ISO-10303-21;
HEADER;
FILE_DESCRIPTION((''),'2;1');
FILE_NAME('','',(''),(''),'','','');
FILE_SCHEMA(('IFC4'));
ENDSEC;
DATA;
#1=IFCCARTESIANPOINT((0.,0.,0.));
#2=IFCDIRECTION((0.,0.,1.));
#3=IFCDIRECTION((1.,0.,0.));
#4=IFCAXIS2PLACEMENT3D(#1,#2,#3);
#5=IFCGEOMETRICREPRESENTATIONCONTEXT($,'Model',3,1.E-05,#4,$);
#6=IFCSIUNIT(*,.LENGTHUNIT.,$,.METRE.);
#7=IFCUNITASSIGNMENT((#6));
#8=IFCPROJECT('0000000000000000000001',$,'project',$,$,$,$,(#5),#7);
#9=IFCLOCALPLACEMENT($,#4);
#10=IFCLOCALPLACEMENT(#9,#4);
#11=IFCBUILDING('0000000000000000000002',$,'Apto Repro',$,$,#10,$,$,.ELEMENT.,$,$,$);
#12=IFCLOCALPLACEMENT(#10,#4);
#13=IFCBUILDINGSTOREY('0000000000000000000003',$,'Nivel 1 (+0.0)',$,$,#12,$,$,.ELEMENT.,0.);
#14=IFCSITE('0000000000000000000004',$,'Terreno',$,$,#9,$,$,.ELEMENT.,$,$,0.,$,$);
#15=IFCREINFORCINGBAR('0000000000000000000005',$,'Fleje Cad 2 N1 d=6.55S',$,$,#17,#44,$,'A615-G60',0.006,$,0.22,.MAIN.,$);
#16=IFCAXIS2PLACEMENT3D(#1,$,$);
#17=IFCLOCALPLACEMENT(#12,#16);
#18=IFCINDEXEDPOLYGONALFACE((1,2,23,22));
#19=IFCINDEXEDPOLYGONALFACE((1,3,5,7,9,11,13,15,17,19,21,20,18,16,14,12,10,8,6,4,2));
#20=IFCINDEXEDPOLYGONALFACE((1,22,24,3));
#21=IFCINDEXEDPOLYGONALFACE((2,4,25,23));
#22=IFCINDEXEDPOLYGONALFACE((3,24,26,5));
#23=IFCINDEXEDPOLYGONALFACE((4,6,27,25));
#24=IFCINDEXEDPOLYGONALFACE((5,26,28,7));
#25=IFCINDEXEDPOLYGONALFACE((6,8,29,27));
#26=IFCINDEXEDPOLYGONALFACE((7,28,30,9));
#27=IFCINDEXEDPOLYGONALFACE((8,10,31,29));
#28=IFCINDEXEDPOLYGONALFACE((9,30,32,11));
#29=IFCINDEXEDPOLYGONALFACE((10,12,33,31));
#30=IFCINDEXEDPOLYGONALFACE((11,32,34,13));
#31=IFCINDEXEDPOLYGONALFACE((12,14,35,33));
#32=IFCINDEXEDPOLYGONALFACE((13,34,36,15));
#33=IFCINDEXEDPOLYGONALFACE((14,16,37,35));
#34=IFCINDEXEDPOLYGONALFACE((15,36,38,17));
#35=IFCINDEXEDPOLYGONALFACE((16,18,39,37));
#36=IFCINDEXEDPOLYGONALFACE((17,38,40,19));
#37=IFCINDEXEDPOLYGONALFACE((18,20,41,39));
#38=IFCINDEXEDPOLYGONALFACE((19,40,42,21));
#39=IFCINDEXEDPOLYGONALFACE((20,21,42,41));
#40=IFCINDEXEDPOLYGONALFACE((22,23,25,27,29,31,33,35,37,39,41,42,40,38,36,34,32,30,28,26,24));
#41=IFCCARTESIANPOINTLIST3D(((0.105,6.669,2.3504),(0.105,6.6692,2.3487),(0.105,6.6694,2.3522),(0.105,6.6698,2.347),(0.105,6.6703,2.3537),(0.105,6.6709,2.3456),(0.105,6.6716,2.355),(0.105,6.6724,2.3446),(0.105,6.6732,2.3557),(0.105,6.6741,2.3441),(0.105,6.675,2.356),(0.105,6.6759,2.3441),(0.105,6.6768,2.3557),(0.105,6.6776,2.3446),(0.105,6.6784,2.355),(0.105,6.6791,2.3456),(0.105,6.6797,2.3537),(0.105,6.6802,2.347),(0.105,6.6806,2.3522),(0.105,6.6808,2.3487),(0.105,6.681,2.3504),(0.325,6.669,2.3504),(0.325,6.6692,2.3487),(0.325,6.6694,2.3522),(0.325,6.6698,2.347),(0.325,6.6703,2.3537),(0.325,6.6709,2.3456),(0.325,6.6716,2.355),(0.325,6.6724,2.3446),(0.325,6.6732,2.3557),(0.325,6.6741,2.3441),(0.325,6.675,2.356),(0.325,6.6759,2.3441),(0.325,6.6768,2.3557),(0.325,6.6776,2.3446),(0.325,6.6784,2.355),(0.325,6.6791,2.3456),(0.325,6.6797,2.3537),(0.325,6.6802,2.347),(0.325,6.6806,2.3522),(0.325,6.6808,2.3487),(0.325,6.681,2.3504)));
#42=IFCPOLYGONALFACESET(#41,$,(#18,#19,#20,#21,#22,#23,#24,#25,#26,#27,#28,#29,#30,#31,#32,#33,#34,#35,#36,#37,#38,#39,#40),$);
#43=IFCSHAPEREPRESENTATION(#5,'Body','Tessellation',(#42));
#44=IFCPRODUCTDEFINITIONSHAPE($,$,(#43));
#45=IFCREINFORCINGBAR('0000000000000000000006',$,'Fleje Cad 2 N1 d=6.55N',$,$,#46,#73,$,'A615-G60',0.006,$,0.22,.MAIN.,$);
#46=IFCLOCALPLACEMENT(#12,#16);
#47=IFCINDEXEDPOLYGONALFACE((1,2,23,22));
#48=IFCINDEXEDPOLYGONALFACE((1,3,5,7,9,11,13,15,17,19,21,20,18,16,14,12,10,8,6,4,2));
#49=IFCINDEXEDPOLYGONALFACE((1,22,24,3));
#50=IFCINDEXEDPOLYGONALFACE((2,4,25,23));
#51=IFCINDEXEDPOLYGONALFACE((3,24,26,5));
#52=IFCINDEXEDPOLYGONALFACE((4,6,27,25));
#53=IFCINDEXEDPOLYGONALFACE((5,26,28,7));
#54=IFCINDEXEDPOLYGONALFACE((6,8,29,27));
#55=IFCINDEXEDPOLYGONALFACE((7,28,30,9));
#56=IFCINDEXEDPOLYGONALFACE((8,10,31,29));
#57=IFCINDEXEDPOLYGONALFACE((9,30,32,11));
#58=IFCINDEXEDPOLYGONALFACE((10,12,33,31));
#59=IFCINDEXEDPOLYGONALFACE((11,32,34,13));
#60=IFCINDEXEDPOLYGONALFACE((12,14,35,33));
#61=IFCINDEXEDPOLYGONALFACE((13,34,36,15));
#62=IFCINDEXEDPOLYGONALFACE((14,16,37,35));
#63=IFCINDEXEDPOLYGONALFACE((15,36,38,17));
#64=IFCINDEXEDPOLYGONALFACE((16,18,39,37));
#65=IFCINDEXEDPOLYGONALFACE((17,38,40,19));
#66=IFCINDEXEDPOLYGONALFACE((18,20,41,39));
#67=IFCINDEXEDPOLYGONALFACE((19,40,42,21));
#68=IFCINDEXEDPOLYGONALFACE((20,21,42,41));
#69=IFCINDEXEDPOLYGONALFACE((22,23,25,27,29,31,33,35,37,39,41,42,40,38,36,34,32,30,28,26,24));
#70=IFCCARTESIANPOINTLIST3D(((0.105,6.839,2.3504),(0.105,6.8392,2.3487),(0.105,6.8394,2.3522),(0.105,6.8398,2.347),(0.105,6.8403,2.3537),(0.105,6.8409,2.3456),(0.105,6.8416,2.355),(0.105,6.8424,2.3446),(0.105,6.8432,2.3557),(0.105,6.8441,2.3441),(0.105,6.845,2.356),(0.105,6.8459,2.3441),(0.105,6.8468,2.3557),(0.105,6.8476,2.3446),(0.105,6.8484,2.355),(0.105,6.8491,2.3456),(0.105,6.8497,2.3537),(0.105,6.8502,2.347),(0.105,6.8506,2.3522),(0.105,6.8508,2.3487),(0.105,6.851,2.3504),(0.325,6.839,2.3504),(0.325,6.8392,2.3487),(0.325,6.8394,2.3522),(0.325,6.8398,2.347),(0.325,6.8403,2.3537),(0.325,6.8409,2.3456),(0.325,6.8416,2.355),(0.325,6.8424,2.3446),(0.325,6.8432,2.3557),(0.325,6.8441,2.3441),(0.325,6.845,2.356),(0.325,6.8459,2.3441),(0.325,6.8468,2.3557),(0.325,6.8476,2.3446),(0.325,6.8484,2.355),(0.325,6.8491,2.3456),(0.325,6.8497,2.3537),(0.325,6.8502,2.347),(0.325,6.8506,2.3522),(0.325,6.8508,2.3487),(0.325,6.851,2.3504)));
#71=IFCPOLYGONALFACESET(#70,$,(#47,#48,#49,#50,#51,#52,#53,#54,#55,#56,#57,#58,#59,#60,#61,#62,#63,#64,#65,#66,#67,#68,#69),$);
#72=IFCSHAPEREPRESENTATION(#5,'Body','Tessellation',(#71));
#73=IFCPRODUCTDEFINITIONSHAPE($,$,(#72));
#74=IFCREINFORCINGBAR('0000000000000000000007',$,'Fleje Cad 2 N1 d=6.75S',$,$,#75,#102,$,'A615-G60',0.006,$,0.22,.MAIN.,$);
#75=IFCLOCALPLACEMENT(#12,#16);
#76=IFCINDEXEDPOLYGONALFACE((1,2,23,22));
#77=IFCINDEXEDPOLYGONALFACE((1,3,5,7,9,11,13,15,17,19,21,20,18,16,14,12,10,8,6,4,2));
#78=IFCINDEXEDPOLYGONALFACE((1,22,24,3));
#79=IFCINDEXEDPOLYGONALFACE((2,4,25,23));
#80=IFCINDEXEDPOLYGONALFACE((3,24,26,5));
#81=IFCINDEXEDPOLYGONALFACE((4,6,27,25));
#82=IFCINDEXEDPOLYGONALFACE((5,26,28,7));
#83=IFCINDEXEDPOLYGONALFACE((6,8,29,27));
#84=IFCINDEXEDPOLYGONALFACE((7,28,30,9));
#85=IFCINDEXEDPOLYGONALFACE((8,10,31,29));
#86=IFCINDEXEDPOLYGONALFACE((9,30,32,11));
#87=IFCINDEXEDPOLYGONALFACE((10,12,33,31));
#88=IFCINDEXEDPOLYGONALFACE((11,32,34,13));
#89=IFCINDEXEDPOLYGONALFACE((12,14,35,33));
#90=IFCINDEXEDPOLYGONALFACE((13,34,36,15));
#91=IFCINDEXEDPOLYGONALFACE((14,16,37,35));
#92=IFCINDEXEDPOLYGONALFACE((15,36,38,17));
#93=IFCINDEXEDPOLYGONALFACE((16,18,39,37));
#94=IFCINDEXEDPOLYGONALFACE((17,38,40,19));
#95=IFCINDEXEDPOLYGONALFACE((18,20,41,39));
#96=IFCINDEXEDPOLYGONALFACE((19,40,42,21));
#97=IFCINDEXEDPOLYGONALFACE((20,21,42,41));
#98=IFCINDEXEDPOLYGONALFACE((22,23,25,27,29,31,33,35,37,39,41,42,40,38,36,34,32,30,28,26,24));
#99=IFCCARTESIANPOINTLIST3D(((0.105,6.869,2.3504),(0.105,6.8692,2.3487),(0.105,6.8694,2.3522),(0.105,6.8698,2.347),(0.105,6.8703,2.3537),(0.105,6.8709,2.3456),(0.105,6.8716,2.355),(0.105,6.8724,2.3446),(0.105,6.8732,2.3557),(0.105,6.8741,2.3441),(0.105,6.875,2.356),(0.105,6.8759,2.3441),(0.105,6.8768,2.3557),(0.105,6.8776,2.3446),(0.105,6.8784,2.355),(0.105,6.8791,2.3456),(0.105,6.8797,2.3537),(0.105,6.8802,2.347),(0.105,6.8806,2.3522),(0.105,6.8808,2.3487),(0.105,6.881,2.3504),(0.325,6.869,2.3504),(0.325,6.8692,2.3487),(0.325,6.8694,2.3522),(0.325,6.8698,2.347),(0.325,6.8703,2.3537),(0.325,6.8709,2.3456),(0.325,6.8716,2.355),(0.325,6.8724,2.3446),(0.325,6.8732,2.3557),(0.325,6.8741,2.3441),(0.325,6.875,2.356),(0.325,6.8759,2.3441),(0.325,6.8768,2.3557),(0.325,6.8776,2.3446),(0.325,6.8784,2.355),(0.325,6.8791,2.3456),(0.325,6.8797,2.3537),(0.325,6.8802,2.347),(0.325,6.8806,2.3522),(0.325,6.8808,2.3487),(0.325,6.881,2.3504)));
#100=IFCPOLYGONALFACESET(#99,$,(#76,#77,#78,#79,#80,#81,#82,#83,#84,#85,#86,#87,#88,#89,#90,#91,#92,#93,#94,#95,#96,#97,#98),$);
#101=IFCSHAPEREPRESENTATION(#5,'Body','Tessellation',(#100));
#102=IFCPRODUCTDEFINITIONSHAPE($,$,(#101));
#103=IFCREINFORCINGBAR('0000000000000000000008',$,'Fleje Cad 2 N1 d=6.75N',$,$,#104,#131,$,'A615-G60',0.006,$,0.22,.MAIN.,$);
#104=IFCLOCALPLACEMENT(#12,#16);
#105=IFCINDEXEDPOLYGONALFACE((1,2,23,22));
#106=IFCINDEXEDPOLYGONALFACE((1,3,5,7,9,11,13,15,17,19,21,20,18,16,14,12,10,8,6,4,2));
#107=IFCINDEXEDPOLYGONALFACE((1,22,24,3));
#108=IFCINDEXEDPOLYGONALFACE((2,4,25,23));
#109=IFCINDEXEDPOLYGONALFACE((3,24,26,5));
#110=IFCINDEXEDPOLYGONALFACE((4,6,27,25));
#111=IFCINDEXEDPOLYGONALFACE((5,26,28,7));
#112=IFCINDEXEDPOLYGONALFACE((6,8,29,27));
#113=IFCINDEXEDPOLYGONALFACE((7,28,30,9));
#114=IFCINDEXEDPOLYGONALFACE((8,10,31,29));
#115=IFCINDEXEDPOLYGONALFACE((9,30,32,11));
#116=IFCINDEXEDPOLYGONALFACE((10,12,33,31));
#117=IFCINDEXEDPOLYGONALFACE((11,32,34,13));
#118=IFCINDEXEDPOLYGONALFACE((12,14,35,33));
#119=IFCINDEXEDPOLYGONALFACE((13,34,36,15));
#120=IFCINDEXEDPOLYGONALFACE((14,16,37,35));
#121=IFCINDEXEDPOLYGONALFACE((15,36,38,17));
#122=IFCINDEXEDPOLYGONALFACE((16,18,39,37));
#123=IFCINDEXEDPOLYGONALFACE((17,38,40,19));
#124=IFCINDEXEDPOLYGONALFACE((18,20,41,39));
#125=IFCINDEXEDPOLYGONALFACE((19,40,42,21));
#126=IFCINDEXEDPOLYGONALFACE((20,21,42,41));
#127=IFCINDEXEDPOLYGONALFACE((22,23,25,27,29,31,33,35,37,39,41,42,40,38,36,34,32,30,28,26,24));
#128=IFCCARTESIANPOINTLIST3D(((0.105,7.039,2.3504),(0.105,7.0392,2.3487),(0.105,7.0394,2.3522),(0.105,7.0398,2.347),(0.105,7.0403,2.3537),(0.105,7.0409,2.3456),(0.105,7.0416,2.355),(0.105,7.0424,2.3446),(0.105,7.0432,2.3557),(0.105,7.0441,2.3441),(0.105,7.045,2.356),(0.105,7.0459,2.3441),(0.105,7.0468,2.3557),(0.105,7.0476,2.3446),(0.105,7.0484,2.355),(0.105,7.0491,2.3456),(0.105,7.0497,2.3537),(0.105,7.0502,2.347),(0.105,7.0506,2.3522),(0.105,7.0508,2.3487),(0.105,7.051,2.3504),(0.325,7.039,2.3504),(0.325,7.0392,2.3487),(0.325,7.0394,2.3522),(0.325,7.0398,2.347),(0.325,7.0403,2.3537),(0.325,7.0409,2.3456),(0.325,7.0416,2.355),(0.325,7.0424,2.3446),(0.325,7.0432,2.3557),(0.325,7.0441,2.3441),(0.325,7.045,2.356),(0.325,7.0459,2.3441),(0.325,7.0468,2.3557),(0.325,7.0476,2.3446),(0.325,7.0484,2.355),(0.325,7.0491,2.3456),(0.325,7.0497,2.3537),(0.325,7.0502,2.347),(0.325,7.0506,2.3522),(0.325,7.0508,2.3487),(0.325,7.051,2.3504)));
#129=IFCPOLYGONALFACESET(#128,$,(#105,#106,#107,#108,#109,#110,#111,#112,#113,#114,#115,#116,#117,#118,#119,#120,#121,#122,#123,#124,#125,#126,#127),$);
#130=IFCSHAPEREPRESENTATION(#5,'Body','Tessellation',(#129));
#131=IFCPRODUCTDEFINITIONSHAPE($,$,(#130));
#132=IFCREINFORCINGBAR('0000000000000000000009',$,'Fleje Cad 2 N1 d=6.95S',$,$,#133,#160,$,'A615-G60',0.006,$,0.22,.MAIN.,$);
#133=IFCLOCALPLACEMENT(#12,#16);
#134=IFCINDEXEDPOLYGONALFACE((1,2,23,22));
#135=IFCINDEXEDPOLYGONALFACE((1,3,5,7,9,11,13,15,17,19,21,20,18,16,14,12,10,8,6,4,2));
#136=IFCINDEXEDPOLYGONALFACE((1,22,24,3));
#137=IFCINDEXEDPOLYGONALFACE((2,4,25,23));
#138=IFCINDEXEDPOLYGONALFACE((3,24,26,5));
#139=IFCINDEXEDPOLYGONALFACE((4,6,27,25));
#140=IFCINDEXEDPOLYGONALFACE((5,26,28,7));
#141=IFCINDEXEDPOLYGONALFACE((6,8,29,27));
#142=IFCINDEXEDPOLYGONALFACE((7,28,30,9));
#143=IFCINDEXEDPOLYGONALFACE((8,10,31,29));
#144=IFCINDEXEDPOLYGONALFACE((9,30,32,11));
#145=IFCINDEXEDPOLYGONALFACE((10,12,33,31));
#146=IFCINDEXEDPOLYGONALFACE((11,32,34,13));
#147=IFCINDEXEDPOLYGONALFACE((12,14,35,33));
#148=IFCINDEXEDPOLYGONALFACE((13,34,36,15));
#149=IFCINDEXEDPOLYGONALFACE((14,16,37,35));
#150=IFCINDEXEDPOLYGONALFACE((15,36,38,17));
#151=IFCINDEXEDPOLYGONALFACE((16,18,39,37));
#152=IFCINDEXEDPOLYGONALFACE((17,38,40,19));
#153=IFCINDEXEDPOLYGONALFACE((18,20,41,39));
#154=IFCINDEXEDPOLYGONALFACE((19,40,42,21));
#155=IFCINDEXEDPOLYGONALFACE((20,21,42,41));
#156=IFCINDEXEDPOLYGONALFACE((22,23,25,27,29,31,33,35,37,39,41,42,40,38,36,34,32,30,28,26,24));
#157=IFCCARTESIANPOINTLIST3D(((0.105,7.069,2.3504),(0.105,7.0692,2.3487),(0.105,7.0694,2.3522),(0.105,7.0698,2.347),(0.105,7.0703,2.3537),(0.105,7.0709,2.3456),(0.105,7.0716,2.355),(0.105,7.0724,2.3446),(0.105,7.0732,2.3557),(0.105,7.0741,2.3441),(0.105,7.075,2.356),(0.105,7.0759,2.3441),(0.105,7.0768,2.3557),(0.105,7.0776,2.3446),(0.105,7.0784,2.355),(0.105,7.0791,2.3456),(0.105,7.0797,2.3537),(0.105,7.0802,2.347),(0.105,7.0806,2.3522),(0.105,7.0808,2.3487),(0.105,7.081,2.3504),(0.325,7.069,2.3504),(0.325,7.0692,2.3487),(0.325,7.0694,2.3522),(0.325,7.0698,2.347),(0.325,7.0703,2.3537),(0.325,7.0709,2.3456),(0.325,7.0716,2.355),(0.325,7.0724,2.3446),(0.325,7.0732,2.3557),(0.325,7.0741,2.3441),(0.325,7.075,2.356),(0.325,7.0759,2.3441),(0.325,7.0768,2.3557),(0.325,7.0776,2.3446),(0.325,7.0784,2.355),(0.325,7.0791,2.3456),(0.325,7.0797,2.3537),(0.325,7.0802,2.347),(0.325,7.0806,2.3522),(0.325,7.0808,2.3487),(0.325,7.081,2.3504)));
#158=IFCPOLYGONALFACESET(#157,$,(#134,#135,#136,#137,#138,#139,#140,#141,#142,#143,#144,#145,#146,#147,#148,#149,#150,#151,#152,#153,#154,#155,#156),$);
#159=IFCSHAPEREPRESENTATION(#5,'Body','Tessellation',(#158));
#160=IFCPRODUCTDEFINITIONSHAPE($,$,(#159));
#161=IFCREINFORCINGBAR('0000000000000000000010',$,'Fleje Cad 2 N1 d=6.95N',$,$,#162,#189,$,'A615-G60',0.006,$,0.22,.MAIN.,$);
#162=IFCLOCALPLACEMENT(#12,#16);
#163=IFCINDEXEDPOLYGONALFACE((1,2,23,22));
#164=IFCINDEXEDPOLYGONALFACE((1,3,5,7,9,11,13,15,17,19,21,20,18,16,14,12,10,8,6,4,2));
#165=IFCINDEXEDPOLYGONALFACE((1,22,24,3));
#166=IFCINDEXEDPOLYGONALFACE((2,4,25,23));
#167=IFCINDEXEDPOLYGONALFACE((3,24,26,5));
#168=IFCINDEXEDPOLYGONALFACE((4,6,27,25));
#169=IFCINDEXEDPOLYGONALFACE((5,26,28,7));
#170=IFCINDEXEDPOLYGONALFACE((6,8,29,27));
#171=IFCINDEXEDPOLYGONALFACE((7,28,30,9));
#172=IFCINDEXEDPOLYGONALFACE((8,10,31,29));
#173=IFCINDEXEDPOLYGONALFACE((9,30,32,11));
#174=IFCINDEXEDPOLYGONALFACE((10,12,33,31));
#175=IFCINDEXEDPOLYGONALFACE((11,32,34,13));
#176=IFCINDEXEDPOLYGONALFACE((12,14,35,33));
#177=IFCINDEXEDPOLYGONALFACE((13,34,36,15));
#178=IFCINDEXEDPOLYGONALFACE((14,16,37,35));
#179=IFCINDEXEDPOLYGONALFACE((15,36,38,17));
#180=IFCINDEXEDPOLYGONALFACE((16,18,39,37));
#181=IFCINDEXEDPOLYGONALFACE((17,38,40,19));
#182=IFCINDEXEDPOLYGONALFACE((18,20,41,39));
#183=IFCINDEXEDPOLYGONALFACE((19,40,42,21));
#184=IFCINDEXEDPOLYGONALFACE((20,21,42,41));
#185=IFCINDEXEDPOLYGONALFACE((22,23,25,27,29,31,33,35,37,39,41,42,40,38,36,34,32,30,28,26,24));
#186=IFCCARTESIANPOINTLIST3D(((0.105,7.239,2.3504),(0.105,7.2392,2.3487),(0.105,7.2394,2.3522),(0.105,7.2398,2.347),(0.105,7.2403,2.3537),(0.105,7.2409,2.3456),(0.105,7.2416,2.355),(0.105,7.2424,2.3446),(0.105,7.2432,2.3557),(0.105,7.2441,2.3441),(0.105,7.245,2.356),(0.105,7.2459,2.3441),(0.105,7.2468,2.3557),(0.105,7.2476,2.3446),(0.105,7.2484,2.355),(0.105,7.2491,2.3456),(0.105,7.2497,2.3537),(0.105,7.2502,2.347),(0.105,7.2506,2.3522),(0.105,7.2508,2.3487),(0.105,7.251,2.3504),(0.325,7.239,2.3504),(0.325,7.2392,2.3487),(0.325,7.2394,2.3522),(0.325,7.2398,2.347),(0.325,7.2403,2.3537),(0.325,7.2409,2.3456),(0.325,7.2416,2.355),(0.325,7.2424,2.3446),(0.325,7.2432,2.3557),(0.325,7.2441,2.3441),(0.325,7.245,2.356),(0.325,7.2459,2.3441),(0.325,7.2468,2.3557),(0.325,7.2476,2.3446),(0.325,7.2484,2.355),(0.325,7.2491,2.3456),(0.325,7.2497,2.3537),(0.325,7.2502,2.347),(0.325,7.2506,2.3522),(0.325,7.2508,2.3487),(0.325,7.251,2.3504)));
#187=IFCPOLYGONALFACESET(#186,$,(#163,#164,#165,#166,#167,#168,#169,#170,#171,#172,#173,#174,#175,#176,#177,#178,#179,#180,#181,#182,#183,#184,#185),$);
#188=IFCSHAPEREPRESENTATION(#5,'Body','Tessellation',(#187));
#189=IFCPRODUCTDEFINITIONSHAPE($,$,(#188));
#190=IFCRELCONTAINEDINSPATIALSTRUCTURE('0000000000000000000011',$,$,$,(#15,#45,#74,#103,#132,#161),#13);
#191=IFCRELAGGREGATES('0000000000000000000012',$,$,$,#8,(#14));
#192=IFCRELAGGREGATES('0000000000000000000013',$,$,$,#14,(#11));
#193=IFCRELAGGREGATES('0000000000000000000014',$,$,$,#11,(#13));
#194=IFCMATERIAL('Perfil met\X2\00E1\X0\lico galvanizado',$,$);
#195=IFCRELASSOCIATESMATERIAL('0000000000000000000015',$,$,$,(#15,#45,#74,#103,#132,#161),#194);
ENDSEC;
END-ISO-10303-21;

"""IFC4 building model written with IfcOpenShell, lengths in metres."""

from ifc_helpers import new_model, si_unit, frame, origin_with_axes, origin_2d_with_axis, place, context, project, spatial, circle, extrude, material, element, save


model = new_model("IFC4")

# Units and contexts
model_context = context("Model", 3, precision=1e-05, world=origin_with_axes())
ifc_project = project(units=[si_unit("LENGTHUNIT", "METRE")], contexts=[model_context])

# Site, building, storey
site_placement = place(None, origin_with_axes())
site = spatial("IfcSite", under=ifc_project, at=site_placement, Name="Terreno", CompositionType="ELEMENT", RefElevation=0.0)
building_placement = place(site_placement, origin_with_axes())
building = spatial("IfcBuilding", under=site, at=building_placement, Name="Apto Repro", CompositionType="ELEMENT")
storey_placement = place(building_placement, origin_with_axes())
storey = spatial("IfcBuildingStorey", under=building, at=storey_placement, Name="Nivel 1 (+0.0)", CompositionType="ELEMENT", Elevation=0.0)

# Reinforcing bars
ifc_material = material(Name="Perfil metálico galvanizado")
reinforcing_bar_1_placement = place(storey_placement, origin_with_axes())
element("IfcReinforcingBar", 1, at=reinforcing_bar_1_placement, inside=storey, material=ifc_material, Name="Fleje Cad 2 N1 d=6.55S", SteelGrade="A615-G60", BarLength=0.22, NominalDiameter=0.006, PredefinedType="MAIN", context=model_context, shape_type="SweptSolid", body=[
    extrude(circle(Radius=0.006, at=origin_2d_with_axis()), frame((0.105, 6.675, 2.35), z_axis=(1.0, 0.0, 0.0), x_axis=(0.0, 0.0, 1.0)), (0.0, 0.0, 1.0), 0.22),
])
reinforcing_bar_2_placement = place(storey_placement, origin_with_axes())
element("IfcReinforcingBar", 2, at=reinforcing_bar_2_placement, inside=storey, material=ifc_material, Name="Fleje Cad 2 N1 d=6.55N", SteelGrade="A615-G60", BarLength=0.22, NominalDiameter=0.006, PredefinedType="MAIN", context=model_context, shape_type="SweptSolid", body=[
    extrude(circle(Radius=0.006, at=origin_2d_with_axis()), frame((0.105, 6.845, 2.35), z_axis=(1.0, 0.0, 0.0), x_axis=(0.0, 0.0, 1.0)), (0.0, 0.0, 1.0), 0.22),
])
reinforcing_bar_3_placement = place(storey_placement, origin_with_axes())
element("IfcReinforcingBar", 3, at=reinforcing_bar_3_placement, inside=storey, material=ifc_material, Name="Fleje Cad 2 N1 d=6.75S", SteelGrade="A615-G60", BarLength=0.22, NominalDiameter=0.006, PredefinedType="MAIN", context=model_context, shape_type="SweptSolid", body=[
    extrude(circle(Radius=0.006, at=origin_2d_with_axis()), frame((0.105, 6.875, 2.35), z_axis=(1.0, 0.0, 0.0), x_axis=(0.0, 0.0, 1.0)), (0.0, 0.0, 1.0), 0.22),
])
reinforcing_bar_4_placement = place(storey_placement, origin_with_axes())
element("IfcReinforcingBar", 4, at=reinforcing_bar_4_placement, inside=storey, material=ifc_material, Name="Fleje Cad 2 N1 d=6.75N", SteelGrade="A615-G60", BarLength=0.22, NominalDiameter=0.006, PredefinedType="MAIN", context=model_context, shape_type="SweptSolid", body=[
    extrude(circle(Radius=0.006, at=origin_2d_with_axis()), frame((0.105, 7.045, 2.35), z_axis=(1.0, 0.0, 0.0), x_axis=(0.0, 0.0, 1.0)), (0.0, 0.0, 1.0), 0.22),
])
reinforcing_bar_5_placement = place(storey_placement, origin_with_axes())
element("IfcReinforcingBar", 5, at=reinforcing_bar_5_placement, inside=storey, material=ifc_material, Name="Fleje Cad 2 N1 d=6.95S", SteelGrade="A615-G60", BarLength=0.22, NominalDiameter=0.006, PredefinedType="MAIN", context=model_context, shape_type="SweptSolid", body=[
    extrude(circle(Radius=0.006, at=origin_2d_with_axis()), frame((0.105, 7.075, 2.35), z_axis=(1.0, 0.0, 0.0), x_axis=(0.0, 0.0, 1.0)), (0.0, 0.0, 1.0), 0.22),
])
reinforcing_bar_6_placement = place(storey_placement, origin_with_axes())
element("IfcReinforcingBar", 6, at=reinforcing_bar_6_placement, inside=storey, material=ifc_material, Name="Fleje Cad 2 N1 d=6.95N", SteelGrade="A615-G60", BarLength=0.22, NominalDiameter=0.006, PredefinedType="MAIN", context=model_context, shape_type="SweptSolid", body=[
    extrude(circle(Radius=0.006, at=origin_2d_with_axis()), frame((0.105, 7.245, 2.35), z_axis=(1.0, 0.0, 0.0), x_axis=(0.0, 0.0, 1.0)), (0.0, 0.0, 1.0), 0.22),
])

save(model, "model.ifc")
